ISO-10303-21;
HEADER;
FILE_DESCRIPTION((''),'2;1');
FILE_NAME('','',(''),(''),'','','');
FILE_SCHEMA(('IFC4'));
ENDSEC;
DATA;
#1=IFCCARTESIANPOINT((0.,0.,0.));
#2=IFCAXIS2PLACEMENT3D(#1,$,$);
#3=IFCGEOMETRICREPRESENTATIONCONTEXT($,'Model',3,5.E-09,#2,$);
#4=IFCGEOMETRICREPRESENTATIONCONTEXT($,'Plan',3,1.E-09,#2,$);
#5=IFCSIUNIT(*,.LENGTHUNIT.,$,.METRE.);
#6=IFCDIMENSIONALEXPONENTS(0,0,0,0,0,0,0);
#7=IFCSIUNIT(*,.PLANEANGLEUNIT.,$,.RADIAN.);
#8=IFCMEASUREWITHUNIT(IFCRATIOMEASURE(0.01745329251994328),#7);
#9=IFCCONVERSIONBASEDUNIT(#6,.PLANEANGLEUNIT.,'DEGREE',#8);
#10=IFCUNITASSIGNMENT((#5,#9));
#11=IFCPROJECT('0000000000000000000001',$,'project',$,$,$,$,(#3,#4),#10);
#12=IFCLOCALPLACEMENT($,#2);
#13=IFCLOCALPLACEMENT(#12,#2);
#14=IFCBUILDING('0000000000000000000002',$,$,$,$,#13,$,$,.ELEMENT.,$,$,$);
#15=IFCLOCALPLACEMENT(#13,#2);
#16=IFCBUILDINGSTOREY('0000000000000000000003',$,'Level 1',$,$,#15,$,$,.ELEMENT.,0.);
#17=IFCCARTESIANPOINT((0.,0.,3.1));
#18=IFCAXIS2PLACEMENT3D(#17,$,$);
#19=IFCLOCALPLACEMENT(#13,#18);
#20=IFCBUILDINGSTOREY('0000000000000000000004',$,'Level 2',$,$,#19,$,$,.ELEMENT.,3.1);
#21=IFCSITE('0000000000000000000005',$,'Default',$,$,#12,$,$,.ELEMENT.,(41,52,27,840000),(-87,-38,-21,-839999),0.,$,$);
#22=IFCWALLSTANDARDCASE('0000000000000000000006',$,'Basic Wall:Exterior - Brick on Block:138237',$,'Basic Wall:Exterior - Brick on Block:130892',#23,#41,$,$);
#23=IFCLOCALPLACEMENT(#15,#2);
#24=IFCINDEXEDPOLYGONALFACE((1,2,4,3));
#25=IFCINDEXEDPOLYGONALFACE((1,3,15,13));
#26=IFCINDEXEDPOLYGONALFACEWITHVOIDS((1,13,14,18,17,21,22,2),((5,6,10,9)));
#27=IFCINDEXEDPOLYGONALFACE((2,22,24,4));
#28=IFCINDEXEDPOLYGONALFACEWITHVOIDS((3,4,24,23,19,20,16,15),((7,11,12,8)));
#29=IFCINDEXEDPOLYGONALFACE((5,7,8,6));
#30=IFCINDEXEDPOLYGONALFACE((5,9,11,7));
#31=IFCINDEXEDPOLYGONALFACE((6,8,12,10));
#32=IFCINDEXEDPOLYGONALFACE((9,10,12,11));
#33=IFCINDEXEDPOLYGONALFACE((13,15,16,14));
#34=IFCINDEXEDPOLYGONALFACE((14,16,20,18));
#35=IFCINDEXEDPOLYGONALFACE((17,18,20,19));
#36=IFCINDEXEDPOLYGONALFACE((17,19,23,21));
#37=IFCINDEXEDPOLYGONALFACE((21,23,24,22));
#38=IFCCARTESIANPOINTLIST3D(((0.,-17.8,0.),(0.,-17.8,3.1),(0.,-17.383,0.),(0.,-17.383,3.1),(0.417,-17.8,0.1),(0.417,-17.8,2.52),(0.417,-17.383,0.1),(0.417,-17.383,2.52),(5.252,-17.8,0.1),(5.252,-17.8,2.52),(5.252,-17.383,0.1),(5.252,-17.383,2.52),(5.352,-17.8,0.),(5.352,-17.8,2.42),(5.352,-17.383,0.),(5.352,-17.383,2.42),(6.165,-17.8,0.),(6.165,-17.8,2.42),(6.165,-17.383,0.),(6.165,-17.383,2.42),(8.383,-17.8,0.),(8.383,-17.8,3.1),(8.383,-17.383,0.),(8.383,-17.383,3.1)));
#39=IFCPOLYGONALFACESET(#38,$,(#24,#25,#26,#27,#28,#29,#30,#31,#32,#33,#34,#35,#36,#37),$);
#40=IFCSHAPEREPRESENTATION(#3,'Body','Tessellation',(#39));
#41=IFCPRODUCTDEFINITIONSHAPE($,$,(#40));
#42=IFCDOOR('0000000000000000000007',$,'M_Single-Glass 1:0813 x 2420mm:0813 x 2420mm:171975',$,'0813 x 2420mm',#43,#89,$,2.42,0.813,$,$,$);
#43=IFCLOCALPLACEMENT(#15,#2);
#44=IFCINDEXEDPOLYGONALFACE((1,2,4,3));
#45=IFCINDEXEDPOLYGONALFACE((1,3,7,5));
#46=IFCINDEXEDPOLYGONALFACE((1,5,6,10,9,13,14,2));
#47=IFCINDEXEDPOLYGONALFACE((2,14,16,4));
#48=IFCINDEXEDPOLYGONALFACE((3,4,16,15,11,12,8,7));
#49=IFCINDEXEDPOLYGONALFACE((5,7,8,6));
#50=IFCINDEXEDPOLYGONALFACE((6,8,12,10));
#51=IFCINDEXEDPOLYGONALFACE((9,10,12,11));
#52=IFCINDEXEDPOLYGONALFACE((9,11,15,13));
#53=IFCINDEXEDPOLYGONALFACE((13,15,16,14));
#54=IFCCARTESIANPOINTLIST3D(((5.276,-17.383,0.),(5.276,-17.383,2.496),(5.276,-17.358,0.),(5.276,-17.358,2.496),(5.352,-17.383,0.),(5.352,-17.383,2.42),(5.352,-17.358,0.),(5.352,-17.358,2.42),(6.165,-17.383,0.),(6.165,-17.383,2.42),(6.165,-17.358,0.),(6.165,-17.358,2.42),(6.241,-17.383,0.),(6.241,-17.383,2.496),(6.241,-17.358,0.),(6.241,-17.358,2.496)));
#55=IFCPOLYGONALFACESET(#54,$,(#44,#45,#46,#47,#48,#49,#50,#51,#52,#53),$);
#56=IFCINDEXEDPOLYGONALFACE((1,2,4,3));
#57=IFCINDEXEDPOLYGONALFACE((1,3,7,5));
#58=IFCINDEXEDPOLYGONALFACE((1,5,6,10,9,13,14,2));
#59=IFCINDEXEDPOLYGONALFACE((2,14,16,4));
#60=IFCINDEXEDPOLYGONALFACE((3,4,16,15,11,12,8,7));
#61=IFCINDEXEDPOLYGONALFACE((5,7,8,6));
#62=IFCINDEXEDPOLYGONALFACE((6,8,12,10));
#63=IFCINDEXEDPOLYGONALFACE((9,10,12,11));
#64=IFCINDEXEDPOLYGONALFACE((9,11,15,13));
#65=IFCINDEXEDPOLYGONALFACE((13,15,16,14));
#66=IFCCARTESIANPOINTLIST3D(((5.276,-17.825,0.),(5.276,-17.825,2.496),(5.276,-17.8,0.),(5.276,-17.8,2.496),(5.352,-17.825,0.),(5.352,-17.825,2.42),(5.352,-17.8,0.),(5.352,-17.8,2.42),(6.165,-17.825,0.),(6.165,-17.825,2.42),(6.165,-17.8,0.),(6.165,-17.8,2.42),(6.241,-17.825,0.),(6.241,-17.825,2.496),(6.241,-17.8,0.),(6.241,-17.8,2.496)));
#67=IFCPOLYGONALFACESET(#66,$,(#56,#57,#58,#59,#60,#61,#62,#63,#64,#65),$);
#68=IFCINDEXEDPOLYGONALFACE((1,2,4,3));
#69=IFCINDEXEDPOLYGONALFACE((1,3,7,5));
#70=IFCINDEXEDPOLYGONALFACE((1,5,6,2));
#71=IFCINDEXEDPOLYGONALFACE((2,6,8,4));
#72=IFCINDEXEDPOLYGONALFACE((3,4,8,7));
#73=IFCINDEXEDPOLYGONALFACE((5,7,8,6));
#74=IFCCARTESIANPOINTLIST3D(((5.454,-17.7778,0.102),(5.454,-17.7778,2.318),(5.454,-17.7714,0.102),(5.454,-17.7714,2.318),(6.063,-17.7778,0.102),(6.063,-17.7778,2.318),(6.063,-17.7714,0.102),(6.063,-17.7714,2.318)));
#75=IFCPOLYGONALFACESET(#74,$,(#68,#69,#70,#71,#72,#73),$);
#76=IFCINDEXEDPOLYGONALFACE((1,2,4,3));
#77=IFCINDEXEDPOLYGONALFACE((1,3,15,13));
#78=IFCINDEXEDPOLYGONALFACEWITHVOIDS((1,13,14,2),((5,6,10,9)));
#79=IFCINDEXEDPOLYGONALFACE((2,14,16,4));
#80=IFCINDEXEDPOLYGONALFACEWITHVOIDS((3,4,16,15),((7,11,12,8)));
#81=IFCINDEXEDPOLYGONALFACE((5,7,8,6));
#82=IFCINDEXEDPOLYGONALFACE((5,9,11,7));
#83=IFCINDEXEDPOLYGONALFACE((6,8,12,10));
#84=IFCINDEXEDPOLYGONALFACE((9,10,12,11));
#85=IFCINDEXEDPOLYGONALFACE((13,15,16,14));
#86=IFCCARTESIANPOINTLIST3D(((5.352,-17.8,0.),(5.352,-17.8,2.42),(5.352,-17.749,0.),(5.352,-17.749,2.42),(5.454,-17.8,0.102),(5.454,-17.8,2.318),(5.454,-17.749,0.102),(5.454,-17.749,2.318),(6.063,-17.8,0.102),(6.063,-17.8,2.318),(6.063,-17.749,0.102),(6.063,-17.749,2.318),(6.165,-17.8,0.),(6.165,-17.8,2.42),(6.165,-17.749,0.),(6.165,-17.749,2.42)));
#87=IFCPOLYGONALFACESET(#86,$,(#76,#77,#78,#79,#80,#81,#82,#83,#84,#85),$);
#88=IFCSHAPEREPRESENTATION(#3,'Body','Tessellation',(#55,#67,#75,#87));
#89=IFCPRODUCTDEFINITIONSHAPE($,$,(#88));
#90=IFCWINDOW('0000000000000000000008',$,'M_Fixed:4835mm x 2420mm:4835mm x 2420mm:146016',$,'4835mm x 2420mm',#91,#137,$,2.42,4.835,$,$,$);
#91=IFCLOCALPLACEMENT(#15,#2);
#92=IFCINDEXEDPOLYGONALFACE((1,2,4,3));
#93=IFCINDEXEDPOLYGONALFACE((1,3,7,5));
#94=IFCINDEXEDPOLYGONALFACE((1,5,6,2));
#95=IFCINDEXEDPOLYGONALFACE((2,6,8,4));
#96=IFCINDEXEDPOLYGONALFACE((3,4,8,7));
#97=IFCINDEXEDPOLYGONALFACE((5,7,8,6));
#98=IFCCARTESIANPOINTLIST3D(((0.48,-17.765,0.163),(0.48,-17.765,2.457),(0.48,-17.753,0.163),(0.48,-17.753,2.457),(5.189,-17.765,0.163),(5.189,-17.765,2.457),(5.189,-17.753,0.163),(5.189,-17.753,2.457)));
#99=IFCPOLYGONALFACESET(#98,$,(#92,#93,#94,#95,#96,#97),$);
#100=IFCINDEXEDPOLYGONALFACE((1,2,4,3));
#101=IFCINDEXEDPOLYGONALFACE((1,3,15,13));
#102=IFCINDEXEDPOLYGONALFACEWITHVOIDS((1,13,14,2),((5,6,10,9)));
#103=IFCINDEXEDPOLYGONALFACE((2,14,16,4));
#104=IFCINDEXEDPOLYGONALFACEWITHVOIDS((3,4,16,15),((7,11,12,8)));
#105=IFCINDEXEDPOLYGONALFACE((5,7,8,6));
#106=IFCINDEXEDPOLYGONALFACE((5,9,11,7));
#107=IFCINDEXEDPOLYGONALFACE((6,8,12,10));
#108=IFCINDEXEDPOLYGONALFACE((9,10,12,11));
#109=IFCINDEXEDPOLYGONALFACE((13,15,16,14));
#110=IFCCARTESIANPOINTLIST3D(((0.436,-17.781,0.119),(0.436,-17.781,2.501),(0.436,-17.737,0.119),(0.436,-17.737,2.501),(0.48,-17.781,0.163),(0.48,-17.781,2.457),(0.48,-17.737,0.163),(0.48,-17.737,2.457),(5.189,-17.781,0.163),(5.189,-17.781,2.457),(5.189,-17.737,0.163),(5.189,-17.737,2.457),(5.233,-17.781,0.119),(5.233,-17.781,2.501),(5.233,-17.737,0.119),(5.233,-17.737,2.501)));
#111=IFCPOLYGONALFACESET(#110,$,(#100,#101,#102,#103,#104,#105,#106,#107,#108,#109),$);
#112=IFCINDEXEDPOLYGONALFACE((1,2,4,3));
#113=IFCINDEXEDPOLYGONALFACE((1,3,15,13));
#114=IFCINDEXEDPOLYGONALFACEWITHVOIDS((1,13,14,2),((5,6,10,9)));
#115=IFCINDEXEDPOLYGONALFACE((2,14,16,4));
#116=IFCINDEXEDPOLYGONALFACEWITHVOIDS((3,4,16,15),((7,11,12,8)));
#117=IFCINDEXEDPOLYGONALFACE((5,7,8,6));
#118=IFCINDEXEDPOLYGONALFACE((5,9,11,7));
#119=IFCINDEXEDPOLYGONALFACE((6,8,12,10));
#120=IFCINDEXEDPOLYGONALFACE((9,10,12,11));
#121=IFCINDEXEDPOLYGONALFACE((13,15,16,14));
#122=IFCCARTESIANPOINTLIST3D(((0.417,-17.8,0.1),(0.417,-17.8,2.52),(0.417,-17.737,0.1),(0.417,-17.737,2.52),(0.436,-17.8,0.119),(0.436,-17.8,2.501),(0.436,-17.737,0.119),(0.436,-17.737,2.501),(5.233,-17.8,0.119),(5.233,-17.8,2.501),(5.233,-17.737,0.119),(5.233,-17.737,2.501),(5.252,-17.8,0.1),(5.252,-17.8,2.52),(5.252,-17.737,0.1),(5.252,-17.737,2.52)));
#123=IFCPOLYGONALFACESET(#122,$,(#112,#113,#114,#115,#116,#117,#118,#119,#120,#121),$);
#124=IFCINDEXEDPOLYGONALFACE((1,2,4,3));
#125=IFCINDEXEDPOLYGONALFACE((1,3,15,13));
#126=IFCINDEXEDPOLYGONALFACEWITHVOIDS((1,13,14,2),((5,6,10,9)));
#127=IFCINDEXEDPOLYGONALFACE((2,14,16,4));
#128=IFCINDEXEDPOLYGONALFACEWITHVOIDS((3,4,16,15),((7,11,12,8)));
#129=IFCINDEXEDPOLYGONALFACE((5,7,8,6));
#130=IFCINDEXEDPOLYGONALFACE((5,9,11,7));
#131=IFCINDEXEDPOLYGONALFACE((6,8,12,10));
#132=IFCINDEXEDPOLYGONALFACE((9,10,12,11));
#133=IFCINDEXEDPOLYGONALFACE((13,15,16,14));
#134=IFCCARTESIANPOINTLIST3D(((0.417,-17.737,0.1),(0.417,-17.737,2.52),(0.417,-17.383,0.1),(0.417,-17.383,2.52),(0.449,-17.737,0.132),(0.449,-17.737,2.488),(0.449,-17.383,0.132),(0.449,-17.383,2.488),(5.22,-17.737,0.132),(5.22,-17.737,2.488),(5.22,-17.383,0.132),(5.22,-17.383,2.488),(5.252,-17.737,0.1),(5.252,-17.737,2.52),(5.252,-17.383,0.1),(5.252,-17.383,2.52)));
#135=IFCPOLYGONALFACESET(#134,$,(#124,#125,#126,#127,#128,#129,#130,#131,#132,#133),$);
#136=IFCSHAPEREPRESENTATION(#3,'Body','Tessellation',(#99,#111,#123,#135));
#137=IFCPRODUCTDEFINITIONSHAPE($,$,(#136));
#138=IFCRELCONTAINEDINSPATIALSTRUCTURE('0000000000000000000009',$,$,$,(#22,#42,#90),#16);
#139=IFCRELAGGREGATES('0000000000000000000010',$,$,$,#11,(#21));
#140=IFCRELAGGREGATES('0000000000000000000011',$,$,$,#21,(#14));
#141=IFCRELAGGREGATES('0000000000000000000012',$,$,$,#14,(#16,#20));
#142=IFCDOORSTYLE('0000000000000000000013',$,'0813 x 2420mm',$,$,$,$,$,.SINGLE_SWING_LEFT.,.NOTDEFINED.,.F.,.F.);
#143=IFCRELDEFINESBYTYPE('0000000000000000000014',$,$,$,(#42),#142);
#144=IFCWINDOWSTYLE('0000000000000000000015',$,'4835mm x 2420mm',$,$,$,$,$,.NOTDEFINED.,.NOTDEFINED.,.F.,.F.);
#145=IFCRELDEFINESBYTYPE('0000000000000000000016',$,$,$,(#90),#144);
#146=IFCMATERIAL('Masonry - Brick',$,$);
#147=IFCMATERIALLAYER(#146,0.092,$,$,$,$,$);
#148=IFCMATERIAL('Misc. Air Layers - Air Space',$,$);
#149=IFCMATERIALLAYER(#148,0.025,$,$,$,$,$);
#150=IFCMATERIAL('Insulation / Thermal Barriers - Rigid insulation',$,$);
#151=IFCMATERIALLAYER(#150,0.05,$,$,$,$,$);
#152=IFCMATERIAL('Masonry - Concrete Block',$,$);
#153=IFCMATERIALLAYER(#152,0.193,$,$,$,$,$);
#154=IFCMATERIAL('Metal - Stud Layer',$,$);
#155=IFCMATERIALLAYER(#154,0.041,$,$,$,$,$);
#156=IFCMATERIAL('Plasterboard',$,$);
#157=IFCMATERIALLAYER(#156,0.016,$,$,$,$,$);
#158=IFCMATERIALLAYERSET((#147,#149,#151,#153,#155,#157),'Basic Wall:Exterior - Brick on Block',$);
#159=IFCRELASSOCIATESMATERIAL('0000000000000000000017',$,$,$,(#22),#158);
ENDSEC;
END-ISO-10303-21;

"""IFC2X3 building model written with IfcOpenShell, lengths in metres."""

from ifc_helpers import new_model, entity, si_unit, converted_unit, frame, frame_2d, origin, origin_2d_with_axis, place, context, project, spatial, polyline, rectangle, outline, extrude, source, transform, mapped, material, layer, layer_set, layer_usage, type_object, type_shapes, element, fill, save


model = new_model("IFC2X3")

# Units and contexts
model_context = context("Model", 3, precision=5e-09, world=origin())
plan_context = context("Plan", 3, precision=1e-09, world=origin())
ifc_project = project(units=[si_unit("LENGTHUNIT", "METRE"), converted_unit("PLANEANGLEUNIT", "DEGREE", entity("IfcRatioMeasure", 0.01745329251994328), si_unit("PLANEANGLEUNIT", "RADIAN"), dimensions=[0, 0, 0, 0, 0, 0, 0])], contexts=[model_context, plan_context])

# Site, building, storey
site_placement = place(None, origin())
site = spatial("IfcSite", under=ifc_project, at=site_placement, Name="Default", CompositionType="ELEMENT", RefLatitude=(41, 52, 27, 840000), RefLongitude=(-87, -38, -21, -839999), RefElevation=0.0)
building_placement = place(site_placement, origin())
building = spatial("IfcBuilding", under=site, at=building_placement, CompositionType="ELEMENT")
storey_1_placement = place(building_placement, origin())
storey_1 = spatial("IfcBuildingStorey", under=building, at=storey_1_placement, Name="Level 1", CompositionType="ELEMENT", Elevation=0.0)

# Shared definitions
ifc_material_1 = material(Name="Masonry - Brick")
ifc_layer_1 = layer(ifc_material_1, 0.092)
ifc_material_2 = material(Name="Misc. Air Layers - Air Space")
ifc_layer_2 = layer(ifc_material_2, 0.025)
ifc_material_3 = material(Name="Insulation / Thermal Barriers - Rigid insulation")
ifc_layer_3 = layer(ifc_material_3, 0.05)
ifc_material_4 = material(Name="Masonry - Concrete Block")
ifc_layer_4 = layer(ifc_material_4, 0.193)
ifc_material_5 = material(Name="Metal - Stud Layer")
ifc_layer_5 = layer(ifc_material_5, 0.041)
ifc_material_6 = material(Name="Plasterboard")
ifc_layer_6 = layer(ifc_material_6, 0.016)
ifc_layer_set_1 = layer_set([ifc_layer_1, ifc_layer_2, ifc_layer_3, ifc_layer_4, ifc_layer_5, ifc_layer_6], Name="Basic Wall:Exterior - Brick on Block")
ifc_layer_usage_1 = layer_usage(ifc_layer_set_1, "AXIS2", "NEGATIVE", 0.2085)

# Shared definitions
storey_2_placement = place(building_placement, frame((0.0, 0.0, 3.1)))
storey_2 = spatial("IfcBuildingStorey", under=building, at=storey_2_placement, Name="Level 2", CompositionType="ELEMENT", Elevation=3.1)

# Wall, openings, door, window
wall_1_placement = place(storey_1_placement, frame((8.383, -17.5915, 0.0), z_axis=(0.0, 0.0, 1.0), x_axis=(-1.0, 0.0, 0.0)))
wall_1 = element("IfcWallStandardCase", 1, at=wall_1_placement, inside=storey_1, material=ifc_layer_usage_1, Name="Basic Wall:Exterior - Brick on Block:138237", ObjectType="Basic Wall:Exterior - Brick on Block:130892", context=model_context, shape_type="SweptSolid", body=[
    extrude(rectangle(XDim=8.383, YDim=0.417, at=frame_2d((4.1915, 0.0), x_axis=(-1.0, 0.0))), origin(), (0.0, 0.0, 1.0), 3.1),
])
opening_1_placement = place(wall_1_placement, frame((3.131, -0.2085, 0.1)))
opening_1 = element("IfcOpeningElement", 2, at=opening_1_placement, cuts=wall_1, ObjectType="Opening", context=model_context, shape_type="SweptSolid", body=[
    extrude(rectangle(XDim=2.42, YDim=4.835, at=frame_2d((1.21, 2.4175), x_axis=(1.0, 0.0))), frame((0.0, 0.0, 0.0), z_axis=(0.0, 1.0, 0.0), x_axis=(0.0, 0.0, 1.0)), (0.0, 0.0, 1.0), 0.417),
])
opening_2_placement = place(wall_1_placement, frame((2.218, -0.2085, 0.0)))
opening_2 = element("IfcOpeningElement", 3, at=opening_2_placement, cuts=wall_1, ObjectType="Opening", context=model_context, shape_type="SweptSolid", body=[
    extrude(rectangle(XDim=0.813, YDim=2.42, at=frame_2d((1.21, 0.4065), x_axis=(0.0, -1.0))), frame((0.0, 0.0, 0.0), z_axis=(0.0, 1.0, 0.0), x_axis=(0.0, 0.0, 1.0)), (0.0, 0.0, 1.0), 0.417),
])
door_style_1 = type_object("IfcDoorStyle", Name="0813 x 2420mm", ConstructionType="NOTDEFINED", OperationType="SINGLE_SWING_LEFT", ParameterTakesPrecedence=False, Sizeable=False)
shared_shape_1 = source(origin(), model_context, "Body", "SweptSolid", [
    extrude(outline(polyline([(-0.4065, -1.191), (-0.4065, 1.229), (-0.4825, 1.229), (-0.4825, -1.267), (0.4825, -1.267), (0.4825, 1.229), (0.4065, 1.229), (0.4065, -1.191), (-0.4065, -1.191)])), frame((0.4065, 0.0, 1.229), z_axis=(0.0, 1.0, 0.0), x_axis=(1.0, 0.0, 0.0)), (0.0, 0.0, -1.0), 0.025),
    extrude(outline(polyline([(-0.4065, -1.191), (-0.4065, 1.229), (-0.4825, 1.229), (-0.4825, -1.267), (0.4825, -1.267), (0.4825, 1.229), (0.4065, 1.229), (0.4065, -1.191), (-0.4065, -1.191)])), frame((0.4065, 0.442, 1.229), z_axis=(0.0, 1.0, 0.0), x_axis=(1.0, 0.0, 0.0)), (0.0, 0.0, -1.0), 0.025),
    extrude(rectangle(XDim=0.609, YDim=0.0064, at=origin_2d_with_axis()), frame((0.4065, 0.3916, 0.102)), (0.0, 0.0, 1.0), 2.216),
    extrude(outline(polyline([(-1.21, -0.4065), (1.21, -0.4065), (1.21, 0.4065), (-1.21, 0.4065), (-1.21, -0.4065)]), holes=[polyline([(-1.108, 0.3045), (1.108, 0.3045), (1.108, -0.3045), (-1.108, -0.3045), (-1.108, 0.3045)])]), frame((0.4065, 0.417, 1.21), z_axis=(0.0, -1.0, 0.0), x_axis=(0.0, 0.0, -1.0)), (0.0, 0.0, 1.0), 0.051),
])
type_shapes(door_style_1, [shared_shape_1])
door_1_placement = place(opening_2_placement, origin())
door_1 = element("IfcDoor", 4, at=door_1_placement, inside=storey_1, type_object=door_style_1, Name="M_Single-Glass 1:0813 x 2420mm:0813 x 2420mm:171975", ObjectType="0813 x 2420mm", OverallHeight=2.42, OverallWidth=0.813, context=model_context, shape_type="MappedRepresentation", body=[
    mapped(shared_shape_1, transform((0.0, 0.0, 0.0), scale=1.0)),
])
fill(opening_2, door_1)
window_style_1 = type_object("IfcWindowStyle", Name="4835mm x 2420mm", ConstructionType="NOTDEFINED", OperationType="NOTDEFINED", ParameterTakesPrecedence=False, Sizeable=False)
shared_shape_2 = source(origin(), model_context, "Body", "SweptSolid", [
    extrude(rectangle(XDim=0.012, YDim=4.709, at=origin_2d_with_axis()), frame((2.4175, 0.376, 0.063), z_axis=(0.0, 0.0, 1.0), x_axis=(0.0, -1.0, 0.0)), (0.0, 0.0, 1.0), 2.294),
    extrude(outline(polyline([(-2.3985, -1.191), (2.3985, -1.191), (2.3985, 1.191), (-2.3985, 1.191), (-2.3985, -1.191)]), holes=[polyline([(-2.3545, -1.147), (-2.3545, 1.147), (2.3545, 1.147), (2.3545, -1.147), (-2.3545, -1.147)])]), frame((2.4175, 0.354, 1.21), z_axis=(0.0, 1.0, 0.0), x_axis=(1.0, 0.0, 0.0)), (0.0, 0.0, 1.0), 0.044),
    extrude(outline(polyline([(-2.4175, -1.21), (2.4175, -1.21), (2.4175, 1.21), (-2.4175, 1.21), (-2.4175, -1.21)]), holes=[polyline([(-2.3985, -1.191), (-2.3985, 1.191), (2.3985, 1.191), (2.3985, -1.191), (-2.3985, -1.191)])]), frame((2.4175, 0.354, 1.21), z_axis=(0.0, 1.0, 0.0), x_axis=(1.0, 0.0, 0.0)), (0.0, 0.0, 1.0), 0.063),
    extrude(outline(polyline([(-2.4175, -1.21), (2.4175, -1.21), (2.4175, 1.21), (-2.4175, 1.21), (-2.4175, -1.21)]), holes=[polyline([(-2.3855, -1.178), (-2.3855, 1.178), (2.3855, 1.178), (2.3855, -1.178), (-2.3855, -1.178)])]), frame((2.4175, 0.0, 1.21), z_axis=(0.0, 1.0, 0.0), x_axis=(1.0, 0.0, 0.0)), (0.0, 0.0, 1.0), 0.354),
])
type_shapes(window_style_1, [shared_shape_2])
window_1_placement = place(opening_1_placement, origin())
window_1 = element("IfcWindow", 5, at=window_1_placement, inside=storey_1, type_object=window_style_1, Name="M_Fixed:4835mm x 2420mm:4835mm x 2420mm:146016", ObjectType="4835mm x 2420mm", OverallHeight=2.42, OverallWidth=4.835, context=model_context, shape_type="MappedRepresentation", body=[
    mapped(shared_shape_2, transform((0.0, 0.0, 0.0), scale=1.0)),
])
fill(opening_1, window_1)

save(model, "model.ifc")
